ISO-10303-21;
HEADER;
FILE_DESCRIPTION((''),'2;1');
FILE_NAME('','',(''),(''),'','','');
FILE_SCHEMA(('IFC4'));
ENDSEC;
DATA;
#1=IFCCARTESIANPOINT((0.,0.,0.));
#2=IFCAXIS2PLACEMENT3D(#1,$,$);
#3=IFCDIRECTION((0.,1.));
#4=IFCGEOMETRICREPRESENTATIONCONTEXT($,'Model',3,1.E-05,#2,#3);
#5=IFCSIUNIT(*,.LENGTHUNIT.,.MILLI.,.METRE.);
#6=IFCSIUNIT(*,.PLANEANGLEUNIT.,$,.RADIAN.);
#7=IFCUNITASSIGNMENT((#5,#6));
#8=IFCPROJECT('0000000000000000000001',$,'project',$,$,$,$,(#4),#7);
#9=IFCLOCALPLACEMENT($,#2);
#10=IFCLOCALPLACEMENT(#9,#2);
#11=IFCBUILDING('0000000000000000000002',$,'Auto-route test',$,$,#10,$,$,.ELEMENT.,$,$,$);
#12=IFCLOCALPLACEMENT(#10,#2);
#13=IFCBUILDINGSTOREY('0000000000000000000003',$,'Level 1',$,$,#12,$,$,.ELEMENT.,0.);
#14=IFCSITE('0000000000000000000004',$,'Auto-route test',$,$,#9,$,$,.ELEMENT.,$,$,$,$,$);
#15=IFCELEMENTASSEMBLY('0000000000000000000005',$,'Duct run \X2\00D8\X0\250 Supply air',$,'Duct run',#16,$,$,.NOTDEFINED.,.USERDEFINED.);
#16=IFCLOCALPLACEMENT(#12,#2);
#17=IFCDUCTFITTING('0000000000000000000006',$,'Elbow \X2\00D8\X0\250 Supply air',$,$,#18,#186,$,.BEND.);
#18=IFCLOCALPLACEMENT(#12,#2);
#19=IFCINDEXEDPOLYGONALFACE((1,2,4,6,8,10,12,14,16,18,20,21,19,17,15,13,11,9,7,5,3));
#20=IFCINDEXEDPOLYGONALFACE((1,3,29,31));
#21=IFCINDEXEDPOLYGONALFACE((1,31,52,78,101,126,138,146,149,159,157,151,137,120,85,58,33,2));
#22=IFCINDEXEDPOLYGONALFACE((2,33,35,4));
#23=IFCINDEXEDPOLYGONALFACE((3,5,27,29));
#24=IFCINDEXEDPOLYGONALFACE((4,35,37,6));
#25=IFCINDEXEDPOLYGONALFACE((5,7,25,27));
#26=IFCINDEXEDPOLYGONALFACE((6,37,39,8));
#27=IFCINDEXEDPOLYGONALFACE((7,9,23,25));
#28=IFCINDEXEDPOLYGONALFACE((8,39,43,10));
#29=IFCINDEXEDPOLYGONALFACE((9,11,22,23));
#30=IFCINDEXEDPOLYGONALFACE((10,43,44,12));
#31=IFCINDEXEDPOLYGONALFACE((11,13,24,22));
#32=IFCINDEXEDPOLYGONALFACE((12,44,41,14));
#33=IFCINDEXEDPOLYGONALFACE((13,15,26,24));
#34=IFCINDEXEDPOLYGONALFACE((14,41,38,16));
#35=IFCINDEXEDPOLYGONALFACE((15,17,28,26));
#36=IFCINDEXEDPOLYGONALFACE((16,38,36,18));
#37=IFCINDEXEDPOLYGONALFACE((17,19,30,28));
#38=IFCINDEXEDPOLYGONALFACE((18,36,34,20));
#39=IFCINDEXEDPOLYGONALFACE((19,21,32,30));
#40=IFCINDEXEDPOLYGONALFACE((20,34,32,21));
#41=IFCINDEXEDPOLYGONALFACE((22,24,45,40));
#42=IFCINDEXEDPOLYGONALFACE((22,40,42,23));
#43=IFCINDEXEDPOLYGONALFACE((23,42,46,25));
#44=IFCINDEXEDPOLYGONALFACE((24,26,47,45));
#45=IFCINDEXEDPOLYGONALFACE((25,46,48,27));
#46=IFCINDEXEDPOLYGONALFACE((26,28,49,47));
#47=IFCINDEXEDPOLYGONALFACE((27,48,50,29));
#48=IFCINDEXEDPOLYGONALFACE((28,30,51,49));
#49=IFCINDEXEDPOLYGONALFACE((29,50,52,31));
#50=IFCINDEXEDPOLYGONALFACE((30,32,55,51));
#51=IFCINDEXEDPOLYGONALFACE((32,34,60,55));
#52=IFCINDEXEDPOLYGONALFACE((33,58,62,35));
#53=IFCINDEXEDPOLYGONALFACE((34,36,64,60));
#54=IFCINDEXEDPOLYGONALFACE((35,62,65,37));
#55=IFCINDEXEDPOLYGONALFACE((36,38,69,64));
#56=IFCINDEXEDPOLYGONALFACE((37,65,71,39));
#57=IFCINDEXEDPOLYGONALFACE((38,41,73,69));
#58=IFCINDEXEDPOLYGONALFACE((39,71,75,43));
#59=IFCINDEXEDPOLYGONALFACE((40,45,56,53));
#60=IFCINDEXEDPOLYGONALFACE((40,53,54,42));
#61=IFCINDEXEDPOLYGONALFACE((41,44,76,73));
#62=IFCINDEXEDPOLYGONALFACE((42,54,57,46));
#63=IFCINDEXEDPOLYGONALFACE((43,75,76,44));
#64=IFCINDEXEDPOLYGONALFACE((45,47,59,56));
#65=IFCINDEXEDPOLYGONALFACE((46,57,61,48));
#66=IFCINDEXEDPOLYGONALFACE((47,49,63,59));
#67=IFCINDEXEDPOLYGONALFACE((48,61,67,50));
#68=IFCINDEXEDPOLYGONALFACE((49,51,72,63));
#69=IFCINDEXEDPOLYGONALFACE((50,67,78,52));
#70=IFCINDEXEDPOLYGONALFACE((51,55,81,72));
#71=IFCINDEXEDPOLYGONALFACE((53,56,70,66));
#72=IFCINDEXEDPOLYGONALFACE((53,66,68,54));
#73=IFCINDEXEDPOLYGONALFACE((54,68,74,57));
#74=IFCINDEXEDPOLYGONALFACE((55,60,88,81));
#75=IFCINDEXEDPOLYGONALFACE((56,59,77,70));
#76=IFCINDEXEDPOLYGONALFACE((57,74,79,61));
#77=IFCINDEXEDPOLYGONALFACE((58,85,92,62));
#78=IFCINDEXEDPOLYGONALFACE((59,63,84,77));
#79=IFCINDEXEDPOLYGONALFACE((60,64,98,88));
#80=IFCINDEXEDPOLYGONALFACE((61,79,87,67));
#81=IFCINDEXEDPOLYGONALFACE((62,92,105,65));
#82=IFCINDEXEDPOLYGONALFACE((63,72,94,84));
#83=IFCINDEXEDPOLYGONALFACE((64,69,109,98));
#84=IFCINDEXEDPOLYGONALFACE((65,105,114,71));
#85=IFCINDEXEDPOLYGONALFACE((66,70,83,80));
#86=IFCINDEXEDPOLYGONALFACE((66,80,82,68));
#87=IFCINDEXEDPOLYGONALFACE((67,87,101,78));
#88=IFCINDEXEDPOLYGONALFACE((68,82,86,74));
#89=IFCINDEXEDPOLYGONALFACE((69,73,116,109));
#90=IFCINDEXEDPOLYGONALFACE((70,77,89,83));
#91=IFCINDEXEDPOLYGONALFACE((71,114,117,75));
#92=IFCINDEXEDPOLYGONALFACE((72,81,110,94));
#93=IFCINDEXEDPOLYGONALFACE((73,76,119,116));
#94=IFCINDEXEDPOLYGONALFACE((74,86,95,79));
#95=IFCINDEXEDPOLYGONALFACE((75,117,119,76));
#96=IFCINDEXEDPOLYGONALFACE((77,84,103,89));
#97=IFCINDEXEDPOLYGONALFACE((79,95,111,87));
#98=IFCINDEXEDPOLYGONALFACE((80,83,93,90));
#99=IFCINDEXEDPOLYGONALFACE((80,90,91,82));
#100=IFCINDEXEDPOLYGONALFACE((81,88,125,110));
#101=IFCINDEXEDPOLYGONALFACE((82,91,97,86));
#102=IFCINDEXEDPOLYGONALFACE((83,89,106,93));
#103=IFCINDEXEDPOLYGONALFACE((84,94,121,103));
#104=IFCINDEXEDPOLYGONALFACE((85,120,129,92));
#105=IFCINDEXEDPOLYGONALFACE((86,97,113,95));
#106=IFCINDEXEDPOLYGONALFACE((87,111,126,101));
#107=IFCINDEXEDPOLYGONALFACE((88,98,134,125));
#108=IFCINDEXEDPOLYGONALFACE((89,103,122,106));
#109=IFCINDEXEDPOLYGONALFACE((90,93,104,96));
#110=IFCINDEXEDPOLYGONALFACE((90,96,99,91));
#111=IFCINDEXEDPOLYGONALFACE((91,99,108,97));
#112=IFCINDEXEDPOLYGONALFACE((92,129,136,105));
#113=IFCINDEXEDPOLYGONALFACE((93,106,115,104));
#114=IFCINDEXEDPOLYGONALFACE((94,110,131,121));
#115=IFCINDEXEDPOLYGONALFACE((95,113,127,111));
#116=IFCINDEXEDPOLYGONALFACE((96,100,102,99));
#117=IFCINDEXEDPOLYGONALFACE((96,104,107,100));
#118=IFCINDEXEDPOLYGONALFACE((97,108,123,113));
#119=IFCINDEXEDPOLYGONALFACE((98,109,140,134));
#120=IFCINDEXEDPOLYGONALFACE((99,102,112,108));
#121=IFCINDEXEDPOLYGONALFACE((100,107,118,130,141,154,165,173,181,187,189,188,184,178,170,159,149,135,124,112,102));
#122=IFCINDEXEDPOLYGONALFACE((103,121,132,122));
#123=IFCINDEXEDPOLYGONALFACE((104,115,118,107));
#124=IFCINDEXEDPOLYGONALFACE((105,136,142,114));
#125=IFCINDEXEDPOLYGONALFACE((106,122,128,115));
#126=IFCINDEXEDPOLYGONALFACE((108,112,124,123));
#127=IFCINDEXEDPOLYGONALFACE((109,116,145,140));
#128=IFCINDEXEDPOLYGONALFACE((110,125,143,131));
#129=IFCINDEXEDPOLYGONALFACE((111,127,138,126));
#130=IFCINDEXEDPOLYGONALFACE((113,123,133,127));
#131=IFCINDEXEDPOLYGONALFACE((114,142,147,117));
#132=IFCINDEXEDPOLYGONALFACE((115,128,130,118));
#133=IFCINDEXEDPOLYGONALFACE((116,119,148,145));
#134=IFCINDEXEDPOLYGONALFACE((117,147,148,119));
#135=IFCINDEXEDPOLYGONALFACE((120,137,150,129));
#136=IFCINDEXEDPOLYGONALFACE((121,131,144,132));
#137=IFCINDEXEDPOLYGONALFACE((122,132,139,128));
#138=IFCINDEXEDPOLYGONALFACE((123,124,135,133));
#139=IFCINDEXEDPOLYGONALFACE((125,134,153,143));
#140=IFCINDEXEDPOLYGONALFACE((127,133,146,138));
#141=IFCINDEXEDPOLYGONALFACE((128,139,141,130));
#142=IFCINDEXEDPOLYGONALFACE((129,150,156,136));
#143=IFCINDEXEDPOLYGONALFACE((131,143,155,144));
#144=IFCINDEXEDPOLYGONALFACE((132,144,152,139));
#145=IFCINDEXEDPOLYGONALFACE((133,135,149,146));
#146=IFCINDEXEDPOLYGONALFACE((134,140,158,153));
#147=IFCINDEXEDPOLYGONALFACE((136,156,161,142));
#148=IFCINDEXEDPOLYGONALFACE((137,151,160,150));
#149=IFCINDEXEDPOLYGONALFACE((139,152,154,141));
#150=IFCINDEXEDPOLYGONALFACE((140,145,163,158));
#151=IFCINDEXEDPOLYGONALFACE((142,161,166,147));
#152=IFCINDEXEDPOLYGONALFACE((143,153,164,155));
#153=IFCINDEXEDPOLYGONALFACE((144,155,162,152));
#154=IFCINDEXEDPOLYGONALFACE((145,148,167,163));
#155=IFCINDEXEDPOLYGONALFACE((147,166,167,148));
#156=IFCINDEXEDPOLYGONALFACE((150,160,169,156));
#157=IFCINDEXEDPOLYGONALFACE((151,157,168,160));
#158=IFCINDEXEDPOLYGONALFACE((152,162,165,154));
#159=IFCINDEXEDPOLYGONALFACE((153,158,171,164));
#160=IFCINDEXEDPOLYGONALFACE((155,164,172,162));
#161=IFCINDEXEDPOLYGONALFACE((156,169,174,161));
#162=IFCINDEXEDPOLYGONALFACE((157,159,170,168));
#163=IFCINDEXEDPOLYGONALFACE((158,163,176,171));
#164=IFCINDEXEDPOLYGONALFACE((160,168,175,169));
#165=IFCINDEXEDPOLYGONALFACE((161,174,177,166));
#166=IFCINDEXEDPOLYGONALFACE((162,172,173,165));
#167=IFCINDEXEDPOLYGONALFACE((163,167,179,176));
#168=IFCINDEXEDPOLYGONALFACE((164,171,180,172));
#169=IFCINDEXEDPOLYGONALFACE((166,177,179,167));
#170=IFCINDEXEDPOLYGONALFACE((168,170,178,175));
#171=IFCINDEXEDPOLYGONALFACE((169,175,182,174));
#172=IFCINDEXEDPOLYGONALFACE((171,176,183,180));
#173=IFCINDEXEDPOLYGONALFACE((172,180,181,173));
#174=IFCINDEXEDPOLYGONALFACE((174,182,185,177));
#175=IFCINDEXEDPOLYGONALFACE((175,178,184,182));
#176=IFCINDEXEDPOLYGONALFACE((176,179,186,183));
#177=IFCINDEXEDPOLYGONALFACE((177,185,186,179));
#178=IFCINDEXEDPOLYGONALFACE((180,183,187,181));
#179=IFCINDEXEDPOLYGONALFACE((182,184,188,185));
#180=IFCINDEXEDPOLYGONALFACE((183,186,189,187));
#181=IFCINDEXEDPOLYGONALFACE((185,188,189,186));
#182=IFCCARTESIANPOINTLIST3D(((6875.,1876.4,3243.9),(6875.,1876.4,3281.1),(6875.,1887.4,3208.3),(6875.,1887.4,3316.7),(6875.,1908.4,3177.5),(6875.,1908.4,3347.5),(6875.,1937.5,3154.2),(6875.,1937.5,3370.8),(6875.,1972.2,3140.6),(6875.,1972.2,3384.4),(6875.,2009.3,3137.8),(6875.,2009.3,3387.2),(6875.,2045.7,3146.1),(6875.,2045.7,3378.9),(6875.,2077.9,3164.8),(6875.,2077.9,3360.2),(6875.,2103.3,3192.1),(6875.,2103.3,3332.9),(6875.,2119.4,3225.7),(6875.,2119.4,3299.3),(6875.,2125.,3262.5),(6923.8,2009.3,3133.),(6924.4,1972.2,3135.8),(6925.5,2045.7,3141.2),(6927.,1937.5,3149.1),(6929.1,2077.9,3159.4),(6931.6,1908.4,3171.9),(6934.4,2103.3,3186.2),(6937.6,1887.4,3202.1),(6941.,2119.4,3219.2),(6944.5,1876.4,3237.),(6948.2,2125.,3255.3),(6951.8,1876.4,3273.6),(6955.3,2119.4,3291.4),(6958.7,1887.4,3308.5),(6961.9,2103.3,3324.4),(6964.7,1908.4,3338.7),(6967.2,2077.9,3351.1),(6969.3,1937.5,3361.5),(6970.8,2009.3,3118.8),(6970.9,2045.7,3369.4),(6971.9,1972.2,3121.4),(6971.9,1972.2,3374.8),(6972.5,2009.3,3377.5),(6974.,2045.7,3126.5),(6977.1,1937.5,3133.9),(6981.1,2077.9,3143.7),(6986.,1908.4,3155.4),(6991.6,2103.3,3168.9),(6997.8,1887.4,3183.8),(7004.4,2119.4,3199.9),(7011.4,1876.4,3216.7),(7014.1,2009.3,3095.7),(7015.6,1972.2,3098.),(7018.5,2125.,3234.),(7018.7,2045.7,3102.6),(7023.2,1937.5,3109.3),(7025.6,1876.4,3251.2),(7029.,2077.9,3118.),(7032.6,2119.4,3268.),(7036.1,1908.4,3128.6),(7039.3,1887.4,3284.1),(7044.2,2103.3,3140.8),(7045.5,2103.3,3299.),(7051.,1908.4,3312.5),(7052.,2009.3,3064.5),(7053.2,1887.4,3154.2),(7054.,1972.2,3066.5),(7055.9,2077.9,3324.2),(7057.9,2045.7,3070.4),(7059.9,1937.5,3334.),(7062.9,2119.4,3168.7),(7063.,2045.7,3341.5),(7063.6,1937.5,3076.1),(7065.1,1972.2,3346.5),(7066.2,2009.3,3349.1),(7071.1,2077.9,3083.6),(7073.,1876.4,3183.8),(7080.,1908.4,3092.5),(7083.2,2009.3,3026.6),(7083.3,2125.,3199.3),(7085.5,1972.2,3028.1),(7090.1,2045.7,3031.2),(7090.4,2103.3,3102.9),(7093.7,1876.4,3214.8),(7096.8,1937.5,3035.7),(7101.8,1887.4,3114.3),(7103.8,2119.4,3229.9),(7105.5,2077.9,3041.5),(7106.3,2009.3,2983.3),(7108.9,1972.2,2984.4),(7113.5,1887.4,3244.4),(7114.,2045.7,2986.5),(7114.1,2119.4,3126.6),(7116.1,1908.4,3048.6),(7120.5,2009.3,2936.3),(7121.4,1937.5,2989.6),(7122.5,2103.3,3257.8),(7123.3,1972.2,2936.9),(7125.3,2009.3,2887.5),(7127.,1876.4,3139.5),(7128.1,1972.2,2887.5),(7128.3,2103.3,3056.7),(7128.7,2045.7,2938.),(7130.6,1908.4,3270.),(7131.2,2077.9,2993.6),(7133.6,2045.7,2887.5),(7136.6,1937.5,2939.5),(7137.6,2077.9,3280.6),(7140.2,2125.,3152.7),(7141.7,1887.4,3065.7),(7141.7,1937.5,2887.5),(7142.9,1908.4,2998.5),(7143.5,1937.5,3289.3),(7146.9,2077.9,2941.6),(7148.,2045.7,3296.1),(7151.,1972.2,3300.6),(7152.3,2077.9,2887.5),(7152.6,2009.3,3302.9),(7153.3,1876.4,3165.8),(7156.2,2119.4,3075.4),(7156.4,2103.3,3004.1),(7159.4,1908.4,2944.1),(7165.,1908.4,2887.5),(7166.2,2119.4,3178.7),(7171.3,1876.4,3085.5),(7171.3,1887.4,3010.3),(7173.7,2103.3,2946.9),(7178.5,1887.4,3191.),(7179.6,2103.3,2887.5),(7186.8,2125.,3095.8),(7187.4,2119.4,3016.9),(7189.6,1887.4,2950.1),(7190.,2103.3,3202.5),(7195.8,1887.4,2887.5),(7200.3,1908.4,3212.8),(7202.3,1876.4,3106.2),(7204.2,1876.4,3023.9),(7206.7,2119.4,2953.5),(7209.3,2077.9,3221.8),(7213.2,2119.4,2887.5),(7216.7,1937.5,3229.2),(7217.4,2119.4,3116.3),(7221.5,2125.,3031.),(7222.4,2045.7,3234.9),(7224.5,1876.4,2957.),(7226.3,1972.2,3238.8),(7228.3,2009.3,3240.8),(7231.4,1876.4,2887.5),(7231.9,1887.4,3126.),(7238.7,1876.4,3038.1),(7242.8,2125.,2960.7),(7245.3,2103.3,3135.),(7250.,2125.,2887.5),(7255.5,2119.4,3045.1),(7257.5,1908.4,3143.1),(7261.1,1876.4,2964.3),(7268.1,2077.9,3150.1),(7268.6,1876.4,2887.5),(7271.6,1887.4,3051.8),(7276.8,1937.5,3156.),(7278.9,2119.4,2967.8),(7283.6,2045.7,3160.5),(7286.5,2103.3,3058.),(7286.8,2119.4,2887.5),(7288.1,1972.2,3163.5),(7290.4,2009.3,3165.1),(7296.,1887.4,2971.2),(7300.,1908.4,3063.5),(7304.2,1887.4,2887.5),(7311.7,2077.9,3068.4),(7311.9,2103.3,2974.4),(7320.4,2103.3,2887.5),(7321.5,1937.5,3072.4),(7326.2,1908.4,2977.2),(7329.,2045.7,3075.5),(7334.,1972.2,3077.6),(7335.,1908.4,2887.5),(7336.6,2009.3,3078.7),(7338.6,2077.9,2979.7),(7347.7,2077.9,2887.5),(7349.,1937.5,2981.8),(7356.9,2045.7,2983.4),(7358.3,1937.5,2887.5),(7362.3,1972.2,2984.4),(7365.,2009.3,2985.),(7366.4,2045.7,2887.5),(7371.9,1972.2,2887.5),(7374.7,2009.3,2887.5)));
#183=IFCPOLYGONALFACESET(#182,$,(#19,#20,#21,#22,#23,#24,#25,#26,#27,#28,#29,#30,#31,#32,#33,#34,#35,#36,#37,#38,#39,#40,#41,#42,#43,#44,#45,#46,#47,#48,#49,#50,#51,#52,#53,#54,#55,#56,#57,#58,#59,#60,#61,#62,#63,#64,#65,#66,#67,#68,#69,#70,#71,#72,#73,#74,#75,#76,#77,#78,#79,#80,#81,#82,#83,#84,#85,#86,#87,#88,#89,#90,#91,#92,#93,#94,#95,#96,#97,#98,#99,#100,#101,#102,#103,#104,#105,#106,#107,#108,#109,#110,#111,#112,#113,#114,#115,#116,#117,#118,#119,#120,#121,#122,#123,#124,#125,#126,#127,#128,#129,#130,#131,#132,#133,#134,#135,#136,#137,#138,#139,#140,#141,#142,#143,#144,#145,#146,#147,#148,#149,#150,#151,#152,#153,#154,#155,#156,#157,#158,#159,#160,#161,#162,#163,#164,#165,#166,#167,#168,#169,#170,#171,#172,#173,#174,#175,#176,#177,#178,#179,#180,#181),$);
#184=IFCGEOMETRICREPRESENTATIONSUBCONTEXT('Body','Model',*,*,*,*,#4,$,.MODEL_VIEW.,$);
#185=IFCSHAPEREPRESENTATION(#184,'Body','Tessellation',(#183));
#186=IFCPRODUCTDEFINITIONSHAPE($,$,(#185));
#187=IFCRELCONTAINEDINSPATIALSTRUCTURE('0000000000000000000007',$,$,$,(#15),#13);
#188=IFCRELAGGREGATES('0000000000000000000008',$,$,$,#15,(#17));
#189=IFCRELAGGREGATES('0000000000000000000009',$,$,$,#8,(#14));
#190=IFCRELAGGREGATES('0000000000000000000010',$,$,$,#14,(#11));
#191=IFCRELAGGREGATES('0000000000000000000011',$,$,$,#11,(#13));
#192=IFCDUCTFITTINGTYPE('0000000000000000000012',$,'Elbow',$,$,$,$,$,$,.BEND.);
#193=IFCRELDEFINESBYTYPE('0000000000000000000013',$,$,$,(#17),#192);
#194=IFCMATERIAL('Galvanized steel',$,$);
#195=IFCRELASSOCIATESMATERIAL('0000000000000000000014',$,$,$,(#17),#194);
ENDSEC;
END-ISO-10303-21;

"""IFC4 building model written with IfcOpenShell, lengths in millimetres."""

from ifc_helpers import new_model, entity, si_unit, direction, origin, origin_with_axes, place, context, subcontext, project, spatial, material, type_object, element, aggregate, save


model = new_model("IFC4")

# Units and contexts
model_context = context("Model", 3, precision=1e-05, world=origin(), true_north=direction((0.0, 1.0)))
body_context = subcontext(model_context, "Body", "Model", "MODEL_VIEW")
ifc_project = project(units=[si_unit("LENGTHUNIT", "METRE", prefix="MILLI"), si_unit("PLANEANGLEUNIT", "RADIAN")], contexts=[model_context])

# Site, building, storey
site_placement = place(None, origin())
site = spatial("IfcSite", under=ifc_project, at=site_placement, Name="Auto-route test", CompositionType="ELEMENT")
building_placement = place(site_placement, origin())
building = spatial("IfcBuilding", under=site, at=building_placement, Name="Auto-route test", CompositionType="ELEMENT")
storey_placement = place(building_placement, origin())
storey = spatial("IfcBuildingStorey", under=building, at=storey_placement, Name="Level 1", CompositionType="ELEMENT", Elevation=0.0)

# Shared definitions
ifc_material_1 = material(Name="Galvanized steel")

# Shared definitions
duct_fitting_type_1 = type_object("IfcDuctFittingType", Name="Elbow", PredefinedType="BEND")

# Element assembly, duct fitting
assembly_1_placement = place(storey_placement, origin_with_axes())
assembly_1 = element("IfcElementAssembly", 1, at=assembly_1_placement, inside=storey, Name="Duct run Ø250 Supply air", ObjectType="Duct run", AssemblyPlace="NOTDEFINED", PredefinedType="USERDEFINED")
duct_fitting_1_placement = place(storey_placement, origin_with_axes())
duct_fitting_1 = element("IfcDuctFitting", 2, at=duct_fitting_1_placement, type_object=duct_fitting_type_1, material=ifc_material_1, Name="Elbow Ø250 Supply air", PredefinedType="BEND", context=body_context, shape_type="SweptSolid", body=[
    entity("IfcRevolvedAreaSolid", entity("IfcCircleProfileDef", "AREA", None, entity("IfcAxis2Placement2D", entity("IfcCartesianPoint", [0.0, 0.0])), 125.0), entity("IfcAxis2Placement3D", entity("IfcCartesianPoint", [6875.0, 2000.0, 3262.5]), entity("IfcDirection", [1.0, 0.0, 0.0]), entity("IfcDirection", [0.0, 1.0, 0.0])), entity("IfcAxis1Placement", entity("IfcCartesianPoint", [0.0, -375.0, 0.0]), entity("IfcDirection", [1.0, 0.0, 0.0])), 1.570796),
])

aggregate(assembly_1, [duct_fitting_1])

save(model, "model.ifc")
